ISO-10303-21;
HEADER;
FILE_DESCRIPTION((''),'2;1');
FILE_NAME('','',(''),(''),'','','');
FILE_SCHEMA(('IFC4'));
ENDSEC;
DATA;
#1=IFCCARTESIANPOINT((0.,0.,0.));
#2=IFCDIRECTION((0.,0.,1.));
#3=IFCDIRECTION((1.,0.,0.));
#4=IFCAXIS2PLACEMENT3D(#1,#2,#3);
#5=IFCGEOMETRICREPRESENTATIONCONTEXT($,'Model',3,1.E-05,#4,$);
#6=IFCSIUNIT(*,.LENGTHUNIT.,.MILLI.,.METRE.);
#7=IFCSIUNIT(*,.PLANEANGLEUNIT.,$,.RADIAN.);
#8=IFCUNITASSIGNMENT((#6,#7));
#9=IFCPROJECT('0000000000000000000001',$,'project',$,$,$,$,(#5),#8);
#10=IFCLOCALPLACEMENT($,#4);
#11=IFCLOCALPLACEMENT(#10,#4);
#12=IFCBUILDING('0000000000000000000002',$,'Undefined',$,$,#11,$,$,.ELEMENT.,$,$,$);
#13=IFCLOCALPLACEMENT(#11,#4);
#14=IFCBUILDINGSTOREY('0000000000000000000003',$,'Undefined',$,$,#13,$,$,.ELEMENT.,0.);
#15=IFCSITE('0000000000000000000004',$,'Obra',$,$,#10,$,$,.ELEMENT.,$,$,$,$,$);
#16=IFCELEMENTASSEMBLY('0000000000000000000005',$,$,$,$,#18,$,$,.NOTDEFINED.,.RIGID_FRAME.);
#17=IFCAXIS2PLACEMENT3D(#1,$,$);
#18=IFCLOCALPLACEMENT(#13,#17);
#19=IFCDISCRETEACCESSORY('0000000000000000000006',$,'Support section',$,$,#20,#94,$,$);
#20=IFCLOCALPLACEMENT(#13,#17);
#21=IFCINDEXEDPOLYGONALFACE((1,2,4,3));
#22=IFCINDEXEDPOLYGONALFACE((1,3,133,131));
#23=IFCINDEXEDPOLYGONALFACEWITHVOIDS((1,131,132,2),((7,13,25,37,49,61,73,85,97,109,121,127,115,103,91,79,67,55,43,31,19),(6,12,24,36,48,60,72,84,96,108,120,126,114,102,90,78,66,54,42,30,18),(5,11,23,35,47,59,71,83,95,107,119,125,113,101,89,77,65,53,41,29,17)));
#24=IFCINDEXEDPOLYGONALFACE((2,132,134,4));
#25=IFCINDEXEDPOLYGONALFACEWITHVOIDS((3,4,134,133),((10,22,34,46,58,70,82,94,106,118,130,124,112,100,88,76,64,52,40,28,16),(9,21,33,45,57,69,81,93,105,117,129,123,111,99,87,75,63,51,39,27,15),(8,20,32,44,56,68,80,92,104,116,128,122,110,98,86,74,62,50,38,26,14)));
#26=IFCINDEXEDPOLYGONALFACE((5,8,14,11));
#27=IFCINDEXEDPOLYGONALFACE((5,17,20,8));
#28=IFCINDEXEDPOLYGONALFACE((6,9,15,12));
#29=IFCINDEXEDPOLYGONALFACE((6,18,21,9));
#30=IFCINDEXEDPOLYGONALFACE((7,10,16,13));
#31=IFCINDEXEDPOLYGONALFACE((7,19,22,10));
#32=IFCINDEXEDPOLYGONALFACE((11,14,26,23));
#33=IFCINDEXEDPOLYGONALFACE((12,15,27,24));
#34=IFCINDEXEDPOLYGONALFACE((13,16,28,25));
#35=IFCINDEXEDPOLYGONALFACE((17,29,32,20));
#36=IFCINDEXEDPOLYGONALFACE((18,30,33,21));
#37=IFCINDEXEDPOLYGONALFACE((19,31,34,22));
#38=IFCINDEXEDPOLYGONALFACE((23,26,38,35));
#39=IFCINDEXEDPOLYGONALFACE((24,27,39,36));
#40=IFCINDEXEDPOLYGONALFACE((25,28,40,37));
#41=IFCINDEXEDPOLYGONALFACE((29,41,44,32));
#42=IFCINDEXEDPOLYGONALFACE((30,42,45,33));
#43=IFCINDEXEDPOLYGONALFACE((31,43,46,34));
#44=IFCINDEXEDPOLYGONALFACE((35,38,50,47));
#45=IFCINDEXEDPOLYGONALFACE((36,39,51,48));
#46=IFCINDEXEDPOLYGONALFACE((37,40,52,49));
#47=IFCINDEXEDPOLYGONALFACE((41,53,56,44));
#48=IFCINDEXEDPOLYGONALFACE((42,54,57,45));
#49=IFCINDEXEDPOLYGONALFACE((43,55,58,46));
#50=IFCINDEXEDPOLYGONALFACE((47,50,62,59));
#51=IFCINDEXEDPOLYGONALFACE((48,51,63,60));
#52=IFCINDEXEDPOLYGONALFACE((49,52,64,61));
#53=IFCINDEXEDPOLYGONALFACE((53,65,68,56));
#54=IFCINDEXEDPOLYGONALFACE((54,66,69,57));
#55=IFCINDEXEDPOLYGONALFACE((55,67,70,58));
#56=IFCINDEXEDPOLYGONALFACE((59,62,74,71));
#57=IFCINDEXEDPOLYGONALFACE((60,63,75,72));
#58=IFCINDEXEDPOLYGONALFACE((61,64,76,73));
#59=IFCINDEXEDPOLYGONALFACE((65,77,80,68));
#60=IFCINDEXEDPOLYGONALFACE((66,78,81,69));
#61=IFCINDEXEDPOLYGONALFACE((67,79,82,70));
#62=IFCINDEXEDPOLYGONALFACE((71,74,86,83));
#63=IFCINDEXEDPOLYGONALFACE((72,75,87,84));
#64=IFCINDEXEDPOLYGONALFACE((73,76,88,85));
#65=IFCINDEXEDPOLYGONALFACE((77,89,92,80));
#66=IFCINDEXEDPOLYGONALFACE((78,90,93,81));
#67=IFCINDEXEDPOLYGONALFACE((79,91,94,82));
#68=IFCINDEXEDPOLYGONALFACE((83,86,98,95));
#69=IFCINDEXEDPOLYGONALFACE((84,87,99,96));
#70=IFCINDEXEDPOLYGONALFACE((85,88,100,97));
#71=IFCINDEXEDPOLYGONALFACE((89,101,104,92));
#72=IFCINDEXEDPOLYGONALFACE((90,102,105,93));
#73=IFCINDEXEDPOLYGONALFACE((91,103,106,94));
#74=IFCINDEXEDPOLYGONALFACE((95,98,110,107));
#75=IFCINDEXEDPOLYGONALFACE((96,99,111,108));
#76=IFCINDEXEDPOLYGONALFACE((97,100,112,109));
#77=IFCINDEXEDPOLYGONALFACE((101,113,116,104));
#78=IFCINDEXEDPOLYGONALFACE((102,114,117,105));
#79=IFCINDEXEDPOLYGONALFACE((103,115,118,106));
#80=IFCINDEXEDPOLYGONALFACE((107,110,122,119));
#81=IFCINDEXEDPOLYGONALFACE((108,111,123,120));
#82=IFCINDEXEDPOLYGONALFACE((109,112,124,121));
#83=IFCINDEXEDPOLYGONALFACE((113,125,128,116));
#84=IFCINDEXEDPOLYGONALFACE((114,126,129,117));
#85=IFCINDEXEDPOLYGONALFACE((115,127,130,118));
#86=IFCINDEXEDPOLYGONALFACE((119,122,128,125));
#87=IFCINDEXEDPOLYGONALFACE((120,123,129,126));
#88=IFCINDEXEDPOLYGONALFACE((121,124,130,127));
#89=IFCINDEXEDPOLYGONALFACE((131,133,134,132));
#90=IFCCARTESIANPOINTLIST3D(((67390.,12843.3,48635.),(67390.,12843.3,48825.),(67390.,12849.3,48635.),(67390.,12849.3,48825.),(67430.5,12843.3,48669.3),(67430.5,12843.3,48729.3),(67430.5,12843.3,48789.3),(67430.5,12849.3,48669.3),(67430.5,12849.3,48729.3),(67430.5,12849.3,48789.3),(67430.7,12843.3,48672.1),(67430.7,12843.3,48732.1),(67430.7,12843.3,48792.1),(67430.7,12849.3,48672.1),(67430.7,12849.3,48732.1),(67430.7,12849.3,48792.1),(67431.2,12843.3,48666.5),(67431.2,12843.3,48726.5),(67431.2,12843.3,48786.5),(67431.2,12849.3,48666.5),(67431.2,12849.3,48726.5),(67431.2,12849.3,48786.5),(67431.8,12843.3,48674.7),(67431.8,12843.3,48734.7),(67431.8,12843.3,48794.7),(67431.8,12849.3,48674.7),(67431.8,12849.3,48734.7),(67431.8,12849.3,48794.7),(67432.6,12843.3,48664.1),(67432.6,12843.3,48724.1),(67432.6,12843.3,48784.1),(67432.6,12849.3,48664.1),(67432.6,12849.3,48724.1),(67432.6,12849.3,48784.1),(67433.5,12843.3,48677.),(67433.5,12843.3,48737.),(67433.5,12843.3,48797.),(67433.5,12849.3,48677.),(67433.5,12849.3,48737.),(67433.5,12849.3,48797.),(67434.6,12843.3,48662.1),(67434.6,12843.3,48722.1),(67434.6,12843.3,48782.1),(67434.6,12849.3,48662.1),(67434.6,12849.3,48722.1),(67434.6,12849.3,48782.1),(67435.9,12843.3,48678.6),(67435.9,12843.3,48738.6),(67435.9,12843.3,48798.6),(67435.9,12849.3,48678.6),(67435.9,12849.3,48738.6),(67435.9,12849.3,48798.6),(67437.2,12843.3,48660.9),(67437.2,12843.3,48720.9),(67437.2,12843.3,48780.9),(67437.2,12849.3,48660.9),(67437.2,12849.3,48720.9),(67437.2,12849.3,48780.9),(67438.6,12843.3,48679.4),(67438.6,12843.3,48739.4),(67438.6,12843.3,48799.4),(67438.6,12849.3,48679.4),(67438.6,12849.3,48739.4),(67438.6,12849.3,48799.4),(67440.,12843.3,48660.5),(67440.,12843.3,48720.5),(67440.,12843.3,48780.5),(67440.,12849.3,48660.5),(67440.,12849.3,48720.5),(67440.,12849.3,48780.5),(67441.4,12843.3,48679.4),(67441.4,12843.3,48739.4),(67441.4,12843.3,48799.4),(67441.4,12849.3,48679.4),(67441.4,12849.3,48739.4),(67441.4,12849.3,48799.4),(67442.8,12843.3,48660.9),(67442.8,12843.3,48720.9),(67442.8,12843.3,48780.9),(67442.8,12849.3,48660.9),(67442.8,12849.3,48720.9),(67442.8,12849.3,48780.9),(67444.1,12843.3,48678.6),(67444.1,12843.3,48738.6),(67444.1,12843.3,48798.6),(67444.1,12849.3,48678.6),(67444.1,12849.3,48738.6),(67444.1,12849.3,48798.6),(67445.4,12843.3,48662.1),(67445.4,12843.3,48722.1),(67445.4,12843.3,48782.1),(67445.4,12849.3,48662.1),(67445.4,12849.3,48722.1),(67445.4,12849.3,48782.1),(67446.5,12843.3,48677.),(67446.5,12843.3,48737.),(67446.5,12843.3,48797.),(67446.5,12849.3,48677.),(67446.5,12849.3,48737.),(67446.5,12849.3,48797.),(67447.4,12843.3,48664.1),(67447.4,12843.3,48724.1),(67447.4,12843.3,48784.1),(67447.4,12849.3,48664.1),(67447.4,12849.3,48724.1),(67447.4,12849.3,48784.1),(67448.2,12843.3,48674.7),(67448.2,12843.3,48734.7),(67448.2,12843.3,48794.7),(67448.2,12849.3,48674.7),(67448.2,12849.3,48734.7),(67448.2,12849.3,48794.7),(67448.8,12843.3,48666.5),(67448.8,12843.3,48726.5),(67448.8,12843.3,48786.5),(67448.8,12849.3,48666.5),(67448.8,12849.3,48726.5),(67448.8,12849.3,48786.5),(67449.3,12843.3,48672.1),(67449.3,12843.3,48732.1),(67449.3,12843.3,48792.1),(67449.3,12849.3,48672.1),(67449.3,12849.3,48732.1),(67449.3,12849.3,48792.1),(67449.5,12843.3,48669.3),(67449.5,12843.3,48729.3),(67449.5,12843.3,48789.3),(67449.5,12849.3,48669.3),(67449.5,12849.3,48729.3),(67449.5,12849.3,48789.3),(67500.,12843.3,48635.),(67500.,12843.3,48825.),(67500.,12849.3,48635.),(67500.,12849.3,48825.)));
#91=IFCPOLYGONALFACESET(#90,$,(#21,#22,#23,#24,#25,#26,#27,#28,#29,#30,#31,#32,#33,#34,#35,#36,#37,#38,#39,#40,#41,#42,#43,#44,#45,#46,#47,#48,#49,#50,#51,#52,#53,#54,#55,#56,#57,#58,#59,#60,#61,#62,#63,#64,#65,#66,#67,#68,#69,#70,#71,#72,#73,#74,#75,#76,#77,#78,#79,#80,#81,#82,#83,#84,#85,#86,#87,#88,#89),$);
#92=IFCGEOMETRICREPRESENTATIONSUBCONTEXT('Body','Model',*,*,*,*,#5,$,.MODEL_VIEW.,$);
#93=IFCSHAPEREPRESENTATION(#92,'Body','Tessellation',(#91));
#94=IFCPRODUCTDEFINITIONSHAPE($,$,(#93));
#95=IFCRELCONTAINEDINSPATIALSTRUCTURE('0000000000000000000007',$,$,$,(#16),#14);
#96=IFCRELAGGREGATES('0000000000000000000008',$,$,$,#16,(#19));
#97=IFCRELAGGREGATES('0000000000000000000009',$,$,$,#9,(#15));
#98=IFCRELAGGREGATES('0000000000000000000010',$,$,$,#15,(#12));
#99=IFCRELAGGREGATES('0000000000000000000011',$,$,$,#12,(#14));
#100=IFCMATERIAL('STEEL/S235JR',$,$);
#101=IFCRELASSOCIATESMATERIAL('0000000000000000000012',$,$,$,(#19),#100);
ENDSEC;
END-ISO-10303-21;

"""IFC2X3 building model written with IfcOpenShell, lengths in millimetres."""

from ifc_helpers import new_model, si_unit, frame, origin_with_axes, origin_2d_with_axis, place, context, subcontext, project, spatial, rectangle, circle, extrude, source, transform, mapped, material, element, aggregate, save


model = new_model("IFC2X3")

# Units and contexts
model_context = context("Model", 3, precision=1e-05, world=origin_with_axes())
body_context = subcontext(model_context, "Body", "Model", "MODEL_VIEW")
ifc_project = project(units=[si_unit("LENGTHUNIT", "METRE", prefix="MILLI"), si_unit("PLANEANGLEUNIT", "RADIAN")], contexts=[model_context])

# Site, building, storey
site_placement = place(None, origin_with_axes())
site = spatial("IfcSite", under=ifc_project, at=site_placement, Name="Obra", CompositionType="ELEMENT")
building_placement = place(site_placement, origin_with_axes())
building = spatial("IfcBuilding", under=site, at=building_placement, Name="Undefined", CompositionType="ELEMENT")
storey_placement = place(building_placement, origin_with_axes())
storey = spatial("IfcBuildingStorey", under=building, at=storey_placement, Name="Undefined", CompositionType="ELEMENT", Elevation=0.0)

# Element assembly
ifc_material_1 = material(Name="STEEL/S235JR")
assembly_1_placement = place(storey_placement, origin_with_axes())
assembly_1 = element("IfcElementAssembly", 1, at=assembly_1_placement, inside=storey, AssemblyPlace="NOTDEFINED", PredefinedType="RIGID_FRAME")

# Discrete accessory, opening
shared_shape_1 = source(origin_with_axes(), body_context, "Body", "SweptSolid", [
    extrude(circle(Radius=9.5, at=origin_2d_with_axis()), frame((0.0, -9.2, 0.0), z_axis=(0.0, 1.0, 0.0), x_axis=(1.0, 0.0, 0.0)), (0.0, 0.0, 1.0), 6.2),
])
discrete_accessory_1_placement = place(assembly_1_placement, frame((67445.0, 12846.3, 48635.0), z_axis=(0.0, 0.0, 1.0), x_axis=(1.0, 0.0, 0.0)))
discrete_accessory_1 = element("IfcDiscreteAccessory", 2, at=discrete_accessory_1_placement, material=ifc_material_1, Name="Support section", context=body_context, shape_type="SweptSolid", body=[
    extrude(rectangle(XDim=6.0, YDim=110.0, at=origin_2d_with_axis()), frame((0.0, 0.0, 190.0), z_axis=(0.0, 0.0, -1.0), x_axis=(0.0, 1.0, 0.0)), (0.0, 0.0, 1.0), 190.0),
])
opening_1_placement = place(assembly_1_placement, frame((67490.0, 12840.2, 48850.0), z_axis=(-1.0, 0.0, 0.0), x_axis=(0.0, 0.0, -1.0)))
element("IfcOpeningElement", 3, at=opening_1_placement, cuts=discrete_accessory_1, ObjectType="Opening", context=body_context, shape_type="MappedRepresentation", body=[
    mapped(shared_shape_1, transform((60.0, 0.0, 50.0))),
    mapped(shared_shape_1, transform((120.0, 0.0, 50.0))),
    mapped(shared_shape_1, transform((180.0, 0.0, 50.0))),
])
aggregate(assembly_1, [discrete_accessory_1])

save(model, "model.ifc")
